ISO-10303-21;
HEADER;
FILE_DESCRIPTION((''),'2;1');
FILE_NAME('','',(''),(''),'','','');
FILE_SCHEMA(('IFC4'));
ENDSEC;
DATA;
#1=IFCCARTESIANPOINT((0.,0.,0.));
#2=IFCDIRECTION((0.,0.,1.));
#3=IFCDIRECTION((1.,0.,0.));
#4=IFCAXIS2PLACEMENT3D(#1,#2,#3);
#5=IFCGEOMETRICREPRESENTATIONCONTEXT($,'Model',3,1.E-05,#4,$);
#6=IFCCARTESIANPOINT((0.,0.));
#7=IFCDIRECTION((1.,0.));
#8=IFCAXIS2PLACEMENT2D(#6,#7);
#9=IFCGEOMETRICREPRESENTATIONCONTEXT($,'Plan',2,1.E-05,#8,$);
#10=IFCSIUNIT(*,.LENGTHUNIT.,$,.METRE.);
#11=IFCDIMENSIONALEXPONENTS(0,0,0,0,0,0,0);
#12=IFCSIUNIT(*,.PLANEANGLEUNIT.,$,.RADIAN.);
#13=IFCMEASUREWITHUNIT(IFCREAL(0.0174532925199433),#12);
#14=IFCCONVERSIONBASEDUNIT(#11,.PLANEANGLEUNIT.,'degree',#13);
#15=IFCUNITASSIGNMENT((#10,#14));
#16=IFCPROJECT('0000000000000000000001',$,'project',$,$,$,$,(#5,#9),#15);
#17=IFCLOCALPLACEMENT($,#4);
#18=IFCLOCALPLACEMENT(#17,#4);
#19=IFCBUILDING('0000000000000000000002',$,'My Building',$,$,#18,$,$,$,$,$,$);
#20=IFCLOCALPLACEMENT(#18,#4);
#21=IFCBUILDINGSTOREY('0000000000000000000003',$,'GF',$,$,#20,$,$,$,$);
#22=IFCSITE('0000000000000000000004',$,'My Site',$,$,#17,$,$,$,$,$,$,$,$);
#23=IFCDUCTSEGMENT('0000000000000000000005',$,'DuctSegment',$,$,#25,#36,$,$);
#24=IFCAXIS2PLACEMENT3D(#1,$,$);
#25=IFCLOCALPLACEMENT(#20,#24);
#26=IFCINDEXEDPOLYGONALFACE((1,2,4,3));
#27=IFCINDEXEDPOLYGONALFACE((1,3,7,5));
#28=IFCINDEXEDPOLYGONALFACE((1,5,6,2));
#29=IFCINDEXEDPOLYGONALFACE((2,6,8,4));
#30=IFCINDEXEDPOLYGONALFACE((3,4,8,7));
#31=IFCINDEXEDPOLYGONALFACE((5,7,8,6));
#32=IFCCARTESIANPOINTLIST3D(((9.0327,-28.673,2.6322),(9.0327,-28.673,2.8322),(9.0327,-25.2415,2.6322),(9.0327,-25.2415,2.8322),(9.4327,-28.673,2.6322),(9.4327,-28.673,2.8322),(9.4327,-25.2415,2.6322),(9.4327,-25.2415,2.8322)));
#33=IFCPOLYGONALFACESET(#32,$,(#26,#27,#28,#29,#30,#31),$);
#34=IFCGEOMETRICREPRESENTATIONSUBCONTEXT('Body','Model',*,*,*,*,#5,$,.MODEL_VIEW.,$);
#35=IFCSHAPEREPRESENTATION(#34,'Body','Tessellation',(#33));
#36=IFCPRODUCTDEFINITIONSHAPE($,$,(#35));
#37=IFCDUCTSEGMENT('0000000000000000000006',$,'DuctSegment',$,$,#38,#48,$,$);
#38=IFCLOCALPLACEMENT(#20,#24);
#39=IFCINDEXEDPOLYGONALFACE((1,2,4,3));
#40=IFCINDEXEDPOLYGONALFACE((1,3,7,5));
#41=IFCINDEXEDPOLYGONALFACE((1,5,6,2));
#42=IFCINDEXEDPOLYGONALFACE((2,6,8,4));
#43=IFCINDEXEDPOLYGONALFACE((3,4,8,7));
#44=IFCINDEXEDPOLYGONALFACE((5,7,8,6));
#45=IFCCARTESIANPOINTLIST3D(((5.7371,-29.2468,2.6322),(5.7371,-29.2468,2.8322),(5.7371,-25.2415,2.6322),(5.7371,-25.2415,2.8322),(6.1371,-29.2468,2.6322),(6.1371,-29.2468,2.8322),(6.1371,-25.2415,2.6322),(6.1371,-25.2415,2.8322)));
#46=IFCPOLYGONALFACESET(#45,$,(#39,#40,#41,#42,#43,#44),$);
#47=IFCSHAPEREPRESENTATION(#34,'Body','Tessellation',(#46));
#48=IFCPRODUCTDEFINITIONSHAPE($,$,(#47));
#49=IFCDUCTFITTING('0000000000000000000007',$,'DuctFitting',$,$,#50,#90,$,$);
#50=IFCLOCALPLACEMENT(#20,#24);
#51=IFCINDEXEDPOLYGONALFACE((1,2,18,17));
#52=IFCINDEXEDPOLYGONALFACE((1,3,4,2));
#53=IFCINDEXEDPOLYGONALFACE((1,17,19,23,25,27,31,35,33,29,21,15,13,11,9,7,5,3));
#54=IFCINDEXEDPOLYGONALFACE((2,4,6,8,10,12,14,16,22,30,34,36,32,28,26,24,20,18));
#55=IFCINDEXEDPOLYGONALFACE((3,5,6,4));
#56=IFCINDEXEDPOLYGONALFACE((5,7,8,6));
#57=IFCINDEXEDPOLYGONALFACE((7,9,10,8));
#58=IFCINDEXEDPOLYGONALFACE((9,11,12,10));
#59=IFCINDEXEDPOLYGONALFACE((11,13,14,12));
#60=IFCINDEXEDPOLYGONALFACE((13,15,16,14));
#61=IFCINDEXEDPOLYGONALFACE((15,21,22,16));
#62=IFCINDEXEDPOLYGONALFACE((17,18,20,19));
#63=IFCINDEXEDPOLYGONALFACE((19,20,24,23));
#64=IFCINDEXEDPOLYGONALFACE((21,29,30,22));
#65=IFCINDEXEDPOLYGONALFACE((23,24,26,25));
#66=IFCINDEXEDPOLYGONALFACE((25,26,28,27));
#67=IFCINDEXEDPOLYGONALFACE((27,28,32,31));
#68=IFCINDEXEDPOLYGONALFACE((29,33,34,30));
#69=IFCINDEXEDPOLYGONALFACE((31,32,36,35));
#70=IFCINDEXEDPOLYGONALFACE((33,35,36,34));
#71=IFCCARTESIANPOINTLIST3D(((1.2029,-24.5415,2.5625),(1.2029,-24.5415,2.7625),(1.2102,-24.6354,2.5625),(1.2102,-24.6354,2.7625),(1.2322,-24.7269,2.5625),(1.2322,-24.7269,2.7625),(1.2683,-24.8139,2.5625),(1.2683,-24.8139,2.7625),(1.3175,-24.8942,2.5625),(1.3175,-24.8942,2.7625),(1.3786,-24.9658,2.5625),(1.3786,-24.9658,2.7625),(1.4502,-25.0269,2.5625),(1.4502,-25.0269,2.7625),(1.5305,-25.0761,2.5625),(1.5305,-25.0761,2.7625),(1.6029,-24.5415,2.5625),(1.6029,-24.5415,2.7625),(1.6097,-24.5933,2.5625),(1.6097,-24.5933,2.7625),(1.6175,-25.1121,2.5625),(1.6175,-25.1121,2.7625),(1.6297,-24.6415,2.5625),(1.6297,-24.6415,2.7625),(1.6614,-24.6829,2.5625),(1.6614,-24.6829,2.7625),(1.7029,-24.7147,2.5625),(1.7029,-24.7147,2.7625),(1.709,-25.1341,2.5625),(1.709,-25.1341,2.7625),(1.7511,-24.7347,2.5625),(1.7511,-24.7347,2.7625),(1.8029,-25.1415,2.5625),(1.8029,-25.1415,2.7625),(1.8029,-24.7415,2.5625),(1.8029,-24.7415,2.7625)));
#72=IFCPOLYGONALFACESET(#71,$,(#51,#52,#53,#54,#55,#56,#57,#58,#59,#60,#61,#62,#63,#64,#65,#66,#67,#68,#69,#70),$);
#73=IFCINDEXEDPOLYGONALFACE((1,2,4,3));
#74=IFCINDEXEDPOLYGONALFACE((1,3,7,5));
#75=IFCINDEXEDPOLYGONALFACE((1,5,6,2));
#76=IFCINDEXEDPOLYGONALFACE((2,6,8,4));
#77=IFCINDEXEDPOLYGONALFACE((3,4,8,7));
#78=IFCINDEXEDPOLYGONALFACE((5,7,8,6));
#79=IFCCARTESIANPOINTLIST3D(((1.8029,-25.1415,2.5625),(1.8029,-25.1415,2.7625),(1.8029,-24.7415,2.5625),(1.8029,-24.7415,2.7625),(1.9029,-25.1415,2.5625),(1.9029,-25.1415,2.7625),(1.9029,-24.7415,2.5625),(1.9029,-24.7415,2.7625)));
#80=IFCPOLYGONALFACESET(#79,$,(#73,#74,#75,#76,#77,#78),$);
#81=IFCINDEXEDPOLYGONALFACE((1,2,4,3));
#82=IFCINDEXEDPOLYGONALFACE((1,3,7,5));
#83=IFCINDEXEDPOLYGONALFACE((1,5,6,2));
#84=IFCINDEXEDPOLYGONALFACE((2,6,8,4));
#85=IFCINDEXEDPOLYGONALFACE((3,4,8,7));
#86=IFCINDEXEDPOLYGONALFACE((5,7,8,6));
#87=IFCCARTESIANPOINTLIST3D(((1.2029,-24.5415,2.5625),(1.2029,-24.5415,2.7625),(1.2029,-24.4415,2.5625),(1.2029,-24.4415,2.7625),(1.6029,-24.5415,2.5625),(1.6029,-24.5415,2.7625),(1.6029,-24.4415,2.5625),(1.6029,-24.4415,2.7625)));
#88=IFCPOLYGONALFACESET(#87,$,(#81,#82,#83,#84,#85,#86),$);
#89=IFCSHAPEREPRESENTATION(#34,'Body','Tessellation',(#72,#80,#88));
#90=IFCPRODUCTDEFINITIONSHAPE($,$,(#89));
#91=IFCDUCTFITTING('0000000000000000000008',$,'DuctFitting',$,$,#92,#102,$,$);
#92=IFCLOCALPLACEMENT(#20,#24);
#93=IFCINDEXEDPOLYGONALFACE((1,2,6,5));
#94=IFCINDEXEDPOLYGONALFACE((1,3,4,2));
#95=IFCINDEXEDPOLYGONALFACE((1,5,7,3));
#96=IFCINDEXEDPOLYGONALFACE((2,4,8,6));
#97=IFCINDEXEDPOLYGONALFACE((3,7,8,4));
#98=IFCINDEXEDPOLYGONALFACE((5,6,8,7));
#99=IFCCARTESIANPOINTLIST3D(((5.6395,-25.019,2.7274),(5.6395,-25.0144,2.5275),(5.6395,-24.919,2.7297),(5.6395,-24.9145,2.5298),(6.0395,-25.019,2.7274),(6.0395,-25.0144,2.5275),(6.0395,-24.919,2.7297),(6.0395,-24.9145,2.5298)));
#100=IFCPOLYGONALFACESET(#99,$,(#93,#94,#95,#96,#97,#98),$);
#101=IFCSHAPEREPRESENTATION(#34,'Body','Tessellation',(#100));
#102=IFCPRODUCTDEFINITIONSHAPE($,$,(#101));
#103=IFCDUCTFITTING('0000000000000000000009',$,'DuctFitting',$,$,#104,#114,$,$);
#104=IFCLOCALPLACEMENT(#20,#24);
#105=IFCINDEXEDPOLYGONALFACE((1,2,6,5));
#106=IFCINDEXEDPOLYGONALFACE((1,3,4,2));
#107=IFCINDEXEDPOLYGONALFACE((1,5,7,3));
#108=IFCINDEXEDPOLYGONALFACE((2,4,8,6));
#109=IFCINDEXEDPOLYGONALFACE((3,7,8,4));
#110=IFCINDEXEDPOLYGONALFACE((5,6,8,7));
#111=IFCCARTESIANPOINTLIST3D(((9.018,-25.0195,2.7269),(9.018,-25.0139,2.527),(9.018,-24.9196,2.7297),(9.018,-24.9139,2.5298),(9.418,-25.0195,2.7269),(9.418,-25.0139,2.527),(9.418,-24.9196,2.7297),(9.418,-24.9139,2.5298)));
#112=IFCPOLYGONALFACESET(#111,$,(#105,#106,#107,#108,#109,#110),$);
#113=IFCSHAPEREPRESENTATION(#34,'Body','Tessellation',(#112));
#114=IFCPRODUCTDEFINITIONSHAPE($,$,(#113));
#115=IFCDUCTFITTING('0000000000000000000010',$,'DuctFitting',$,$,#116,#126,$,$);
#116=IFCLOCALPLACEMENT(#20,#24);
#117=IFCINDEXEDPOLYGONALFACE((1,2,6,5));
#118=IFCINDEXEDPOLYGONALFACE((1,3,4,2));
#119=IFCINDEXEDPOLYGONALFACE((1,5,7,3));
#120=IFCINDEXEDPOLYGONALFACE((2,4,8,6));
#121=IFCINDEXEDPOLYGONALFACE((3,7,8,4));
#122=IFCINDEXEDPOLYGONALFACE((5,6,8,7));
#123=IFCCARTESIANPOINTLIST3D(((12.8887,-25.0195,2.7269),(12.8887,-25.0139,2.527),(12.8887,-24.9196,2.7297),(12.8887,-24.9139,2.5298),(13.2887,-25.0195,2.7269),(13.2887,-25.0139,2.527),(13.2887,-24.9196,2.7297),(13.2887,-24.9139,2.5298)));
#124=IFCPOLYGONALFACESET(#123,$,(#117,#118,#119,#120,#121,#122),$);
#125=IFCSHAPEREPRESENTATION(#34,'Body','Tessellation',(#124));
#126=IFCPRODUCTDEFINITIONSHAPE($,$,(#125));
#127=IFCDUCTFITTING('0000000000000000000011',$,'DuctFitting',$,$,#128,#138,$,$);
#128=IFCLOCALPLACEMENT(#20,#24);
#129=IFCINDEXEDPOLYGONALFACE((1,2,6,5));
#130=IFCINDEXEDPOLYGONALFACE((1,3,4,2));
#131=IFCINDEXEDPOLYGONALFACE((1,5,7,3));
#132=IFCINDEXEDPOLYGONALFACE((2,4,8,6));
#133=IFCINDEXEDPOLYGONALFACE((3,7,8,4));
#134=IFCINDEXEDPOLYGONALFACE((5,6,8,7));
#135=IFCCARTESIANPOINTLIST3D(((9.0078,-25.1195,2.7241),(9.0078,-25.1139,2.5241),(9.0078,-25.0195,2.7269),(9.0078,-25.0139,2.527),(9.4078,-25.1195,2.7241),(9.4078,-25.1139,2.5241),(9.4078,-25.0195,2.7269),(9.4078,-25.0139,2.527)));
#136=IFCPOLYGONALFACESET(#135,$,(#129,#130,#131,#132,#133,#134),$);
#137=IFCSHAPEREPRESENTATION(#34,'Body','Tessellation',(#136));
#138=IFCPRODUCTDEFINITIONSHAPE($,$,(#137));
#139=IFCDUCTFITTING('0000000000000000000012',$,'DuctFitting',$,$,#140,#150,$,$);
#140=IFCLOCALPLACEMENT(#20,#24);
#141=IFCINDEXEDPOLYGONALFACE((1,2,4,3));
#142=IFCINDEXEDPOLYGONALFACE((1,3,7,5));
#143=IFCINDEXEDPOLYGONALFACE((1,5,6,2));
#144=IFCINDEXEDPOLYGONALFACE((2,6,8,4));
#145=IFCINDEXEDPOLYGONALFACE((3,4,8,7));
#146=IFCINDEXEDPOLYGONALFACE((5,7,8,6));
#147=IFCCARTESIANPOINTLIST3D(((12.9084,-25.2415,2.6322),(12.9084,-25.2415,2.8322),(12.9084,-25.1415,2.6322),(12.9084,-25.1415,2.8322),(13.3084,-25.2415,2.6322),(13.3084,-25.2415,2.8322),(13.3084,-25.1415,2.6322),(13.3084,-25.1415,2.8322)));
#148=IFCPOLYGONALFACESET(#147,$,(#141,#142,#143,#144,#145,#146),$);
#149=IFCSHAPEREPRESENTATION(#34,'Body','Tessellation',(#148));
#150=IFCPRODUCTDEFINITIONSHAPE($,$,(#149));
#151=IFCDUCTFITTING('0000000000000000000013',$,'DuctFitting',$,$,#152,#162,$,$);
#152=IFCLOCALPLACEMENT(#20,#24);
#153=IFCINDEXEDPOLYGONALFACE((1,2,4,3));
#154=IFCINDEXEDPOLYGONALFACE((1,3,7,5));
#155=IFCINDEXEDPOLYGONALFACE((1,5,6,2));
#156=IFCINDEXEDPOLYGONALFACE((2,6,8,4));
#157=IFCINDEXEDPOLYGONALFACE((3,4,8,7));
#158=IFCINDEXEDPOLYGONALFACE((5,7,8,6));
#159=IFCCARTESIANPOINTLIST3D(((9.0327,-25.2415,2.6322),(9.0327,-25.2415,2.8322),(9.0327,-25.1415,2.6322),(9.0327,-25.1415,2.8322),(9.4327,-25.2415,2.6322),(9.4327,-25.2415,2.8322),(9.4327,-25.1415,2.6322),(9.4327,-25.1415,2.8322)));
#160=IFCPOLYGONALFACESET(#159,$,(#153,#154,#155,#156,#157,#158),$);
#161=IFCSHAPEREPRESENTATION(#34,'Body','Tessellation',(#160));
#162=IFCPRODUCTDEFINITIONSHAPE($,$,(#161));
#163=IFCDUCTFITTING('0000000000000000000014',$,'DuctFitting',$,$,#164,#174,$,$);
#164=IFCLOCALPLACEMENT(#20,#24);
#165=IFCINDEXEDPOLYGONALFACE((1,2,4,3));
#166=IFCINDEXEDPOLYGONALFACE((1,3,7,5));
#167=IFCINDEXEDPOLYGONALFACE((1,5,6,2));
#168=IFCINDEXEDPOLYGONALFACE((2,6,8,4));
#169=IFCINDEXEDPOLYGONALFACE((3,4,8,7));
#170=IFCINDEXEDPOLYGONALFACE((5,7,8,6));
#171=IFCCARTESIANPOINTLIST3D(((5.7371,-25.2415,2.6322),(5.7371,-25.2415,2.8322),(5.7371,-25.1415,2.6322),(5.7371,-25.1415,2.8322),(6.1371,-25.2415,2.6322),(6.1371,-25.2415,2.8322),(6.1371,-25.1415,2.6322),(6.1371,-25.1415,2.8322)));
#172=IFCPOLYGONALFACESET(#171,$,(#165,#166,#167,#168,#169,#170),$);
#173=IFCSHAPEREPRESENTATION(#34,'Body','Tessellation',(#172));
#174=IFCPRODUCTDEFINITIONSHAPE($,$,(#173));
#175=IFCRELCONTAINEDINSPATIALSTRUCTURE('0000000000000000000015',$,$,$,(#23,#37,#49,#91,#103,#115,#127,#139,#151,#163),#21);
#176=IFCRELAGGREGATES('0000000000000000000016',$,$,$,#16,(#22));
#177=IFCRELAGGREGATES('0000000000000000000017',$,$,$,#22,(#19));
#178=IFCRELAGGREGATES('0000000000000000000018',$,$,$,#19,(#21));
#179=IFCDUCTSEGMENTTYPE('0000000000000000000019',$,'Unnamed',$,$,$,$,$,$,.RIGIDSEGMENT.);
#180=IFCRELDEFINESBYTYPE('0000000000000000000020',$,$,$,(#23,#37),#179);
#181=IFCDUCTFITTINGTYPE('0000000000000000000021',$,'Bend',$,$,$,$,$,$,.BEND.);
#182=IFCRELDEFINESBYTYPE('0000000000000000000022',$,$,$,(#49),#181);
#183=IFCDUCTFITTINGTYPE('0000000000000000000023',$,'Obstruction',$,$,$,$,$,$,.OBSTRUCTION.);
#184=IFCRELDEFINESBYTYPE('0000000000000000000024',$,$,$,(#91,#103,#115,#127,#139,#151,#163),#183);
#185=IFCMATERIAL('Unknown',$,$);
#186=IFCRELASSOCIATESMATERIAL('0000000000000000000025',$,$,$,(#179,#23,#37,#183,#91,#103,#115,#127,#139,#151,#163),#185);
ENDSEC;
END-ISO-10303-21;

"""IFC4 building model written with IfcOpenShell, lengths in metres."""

from ifc_helpers import new_model, entity, si_unit, converted_unit, frame, origin_with_axes, origin_2d_with_axis, place, context, subcontext, project, spatial, line, arc, indexed_curve, rectangle, outline, extrude, source, transform, mapped, material, material_profile, profile_set, profile_usage, type_object, type_shapes, element, save


model = new_model("IFC4")

# Units and contexts
model_context = context("Model", 3, precision=1e-05, world=origin_with_axes())
plan_context = context("Plan", 2, precision=1e-05, world=origin_2d_with_axis())
body_context_1 = subcontext(model_context, "Body", "Model", "MODEL_VIEW")
ifc_project = project(units=[si_unit("LENGTHUNIT", "METRE"), converted_unit("PLANEANGLEUNIT", "degree", entity("IfcReal", 0.0174532925199433), si_unit("PLANEANGLEUNIT", "RADIAN"), dimensions=[0, 0, 0, 0, 0, 0, 0])], contexts=[model_context, plan_context])

# Site, building, storey
site_placement = place(None, origin_with_axes())
site = spatial("IfcSite", under=ifc_project, at=site_placement, Name="My Site")
building_placement = place(site_placement, origin_with_axes())
building = spatial("IfcBuilding", under=site, at=building_placement, Name="My Building")
storey_placement = place(building_placement, origin_with_axes())
storey = spatial("IfcBuildingStorey", under=building, at=storey_placement, Name="GF")

# Shared definitions
ifc_material = material(Name="Unknown")

# Duct segments
ifc_material_profile_1 = material_profile(ifc_material, rectangle(XDim=0.4, YDim=0.2))
ifc_profile_set_1 = profile_set([ifc_material_profile_1])
duct_segment_type = type_object("IfcDuctSegmentType", Name="Unnamed", PredefinedType="RIGIDSEGMENT", material=ifc_profile_set_1)
ifc_profile_usage_1 = profile_usage(ifc_profile_set_1, cardinal=5)
duct_segment_1_placement = place(storey_placement, frame((9.2327, -25.2415, 2.7322), z_axis=(0.0, -1.0, 0.0), x_axis=(1.0, 0.0, 0.0)))
element("IfcDuctSegment", 1, at=duct_segment_1_placement, inside=storey, type_object=duct_segment_type, material=ifc_profile_usage_1, Name="DuctSegment", context=body_context_1, shape_type="SweptSolid", body=[
    extrude(rectangle(XDim=0.4, YDim=0.2), origin_with_axes(), (0.0, 0.0, 1.0), 3.4315),
])
ifc_profile_usage_2 = profile_usage(ifc_profile_set_1, cardinal=5)
duct_segment_2_placement = place(storey_placement, frame((5.9371, -25.2415, 2.7322), z_axis=(0.0, -1.0, 0.0), x_axis=(1.0, 0.0, 0.0)))
element("IfcDuctSegment", 2, at=duct_segment_2_placement, inside=storey, type_object=duct_segment_type, material=ifc_profile_usage_2, Name="DuctSegment", context=body_context_1, shape_type="SweptSolid", body=[
    extrude(rectangle(XDim=0.4, YDim=0.2), origin_with_axes(), (0.0, 0.0, 1.0), 4.0053),
])

# Duct fittings
duct_fitting_type_1 = type_object("IfcDuctFittingType", Name="Bend", PredefinedType="BEND")
shared_shape_1 = source(origin_with_axes(), body_context_1, "Body", "SweptSolid", [
    extrude(outline(indexed_curve([(0.2, 0.0), (0.2586, -0.1414), (0.4, -0.2), (0.4, -0.6), (-0.0243, -0.4243), (-0.2, 0.0)], segments=[arc(1, 2, 3), line(3, 4), arc(4, 5, 6), line(6, 1)])), frame((0.0, -0.1, -0.1), z_axis=(0.0, -1.0, 0.0), x_axis=(1.0, 0.0, 0.0)), (0.0, 0.0, -1.0), 0.2),
    extrude(rectangle(XDim=0.4, YDim=0.2), origin_with_axes(), (0.0, 0.0, -1.0), 0.1),
    extrude(rectangle(XDim=0.4, YDim=0.2), frame((0.4, 0.0, -0.5), z_axis=(1.0, 0.0, 0.0), x_axis=(0.0, 0.0, 1.0)), (0.0, 0.0, 1.0), 0.1),
])
type_shapes(duct_fitting_type_1, [shared_shape_1])
duct_fitting_1_placement = place(storey_placement, frame((1.9029, -24.9415, 2.6625), z_axis=(1.0, 0.0, 0.0), x_axis=(0.0, 1.0, 0.0)))
element("IfcDuctFitting", 3, at=duct_fitting_1_placement, inside=storey, type_object=duct_fitting_type_1, Name="DuctFitting", context=body_context_1, shape_type="MappedRepresentation", body=[
    mapped(shared_shape_1, transform((0.0, 0.0, 0.0), x_axis=(1.0, 0.0, 0.0), y_axis=(0.0, 1.0, 0.0), z_axis=(0.0, 0.0, 1.0), scale=1.0)),
])
ifc_material_profile_2 = material_profile(ifc_material, rectangle(XDim=0.4, YDim=0.2))
ifc_profile_set_2 = profile_set([ifc_material_profile_2])
ifc_profile_usage_3 = profile_usage(ifc_profile_set_2, cardinal=5)
duct_fitting_type_2 = type_object("IfcDuctFittingType", Name="Obstruction", PredefinedType="OBSTRUCTION", material=ifc_profile_set_2)
duct_fitting_2_placement = place(storey_placement, frame((5.8395, -24.9167, 2.6297), z_axis=(0.0, -0.999736, -0.022998), x_axis=(1.0, 0.0, 0.0)))
element("IfcDuctFitting", 4, at=duct_fitting_2_placement, inside=storey, type_object=duct_fitting_type_2, material=ifc_profile_usage_3, Name="DuctFitting", context=body_context_1, shape_type="SweptSolid", body=[
    extrude(rectangle(XDim=0.4, YDim=0.2), origin_with_axes(), (0.0, 0.0, 1.0), 0.1),
])
ifc_profile_usage_4 = profile_usage(ifc_profile_set_2, cardinal=5)
duct_fitting_3_placement = place(storey_placement, frame((9.218, -24.9167, 2.6297), z_axis=(0.0, -0.999605, -0.02812), x_axis=(1.0, 0.0, 0.0)))
element("IfcDuctFitting", 5, at=duct_fitting_3_placement, inside=storey, type_object=duct_fitting_type_2, material=ifc_profile_usage_4, Name="DuctFitting", context=body_context_1, shape_type="SweptSolid", body=[
    extrude(rectangle(XDim=0.4, YDim=0.2), origin_with_axes(), (0.0, 0.0, 1.0), 0.1),
])
ifc_profile_usage_5 = profile_usage(ifc_profile_set_2, cardinal=5)
duct_fitting_4_placement = place(storey_placement, frame((13.0887, -24.9167, 2.6297), z_axis=(0.0, -0.999605, -0.02812), x_axis=(1.0, 0.0, 0.0)))
element("IfcDuctFitting", 6, at=duct_fitting_4_placement, inside=storey, type_object=duct_fitting_type_2, material=ifc_profile_usage_5, Name="DuctFitting", context=body_context_1, shape_type="SweptSolid", body=[
    extrude(rectangle(XDim=0.4, YDim=0.2), origin_with_axes(), (0.0, 0.0, 1.0), 0.1),
])
ifc_profile_usage_6 = profile_usage(ifc_profile_set_2, cardinal=5)
duct_fitting_5_placement = place(storey_placement, frame((9.2078, -25.0167, 2.6269), z_axis=(0.0, -0.999605, -0.02812), x_axis=(1.0, 0.0, 0.0)))
element("IfcDuctFitting", 7, at=duct_fitting_5_placement, inside=storey, type_object=duct_fitting_type_2, material=ifc_profile_usage_6, Name="DuctFitting", context=body_context_1, shape_type="SweptSolid", body=[
    extrude(rectangle(XDim=0.4, YDim=0.2), origin_with_axes(), (0.0, 0.0, 1.0), 0.1),
])
ifc_profile_usage_7 = profile_usage(ifc_profile_set_2, cardinal=5)
duct_fitting_6_placement = place(storey_placement, frame((13.1084, -25.1415, 2.7322), z_axis=(0.0, -1.0, 0.0), x_axis=(1.0, 0.0, 0.0)))
element("IfcDuctFitting", 8, at=duct_fitting_6_placement, inside=storey, type_object=duct_fitting_type_2, material=ifc_profile_usage_7, Name="DuctFitting", context=body_context_1, shape_type="SweptSolid", body=[
    extrude(rectangle(XDim=0.4, YDim=0.2), origin_with_axes(), (0.0, 0.0, 1.0), 0.1),
])
ifc_profile_usage_8 = profile_usage(ifc_profile_set_2, cardinal=5)
duct_fitting_7_placement = place(storey_placement, frame((9.2327, -25.1415, 2.7322), z_axis=(0.0, -1.0, 0.0), x_axis=(1.0, 0.0, 0.0)))
element("IfcDuctFitting", 9, at=duct_fitting_7_placement, inside=storey, type_object=duct_fitting_type_2, material=ifc_profile_usage_8, Name="DuctFitting", context=body_context_1, shape_type="SweptSolid", body=[
    extrude(rectangle(XDim=0.4, YDim=0.2), origin_with_axes(), (0.0, 0.0, 1.0), 0.1),
])
ifc_profile_usage_9 = profile_usage(ifc_profile_set_2, cardinal=5)
duct_fitting_8_placement = place(storey_placement, frame((5.9371, -25.1415, 2.7322), z_axis=(0.0, -1.0, 0.0), x_axis=(1.0, 0.0, 0.0)))
element("IfcDuctFitting", 10, at=duct_fitting_8_placement, inside=storey, type_object=duct_fitting_type_2, material=ifc_profile_usage_9, Name="DuctFitting", context=body_context_1, shape_type="SweptSolid", body=[
    extrude(rectangle(XDim=0.4, YDim=0.2), origin_with_axes(), (0.0, 0.0, 1.0), 0.1),
])

save(model, "model.ifc")
